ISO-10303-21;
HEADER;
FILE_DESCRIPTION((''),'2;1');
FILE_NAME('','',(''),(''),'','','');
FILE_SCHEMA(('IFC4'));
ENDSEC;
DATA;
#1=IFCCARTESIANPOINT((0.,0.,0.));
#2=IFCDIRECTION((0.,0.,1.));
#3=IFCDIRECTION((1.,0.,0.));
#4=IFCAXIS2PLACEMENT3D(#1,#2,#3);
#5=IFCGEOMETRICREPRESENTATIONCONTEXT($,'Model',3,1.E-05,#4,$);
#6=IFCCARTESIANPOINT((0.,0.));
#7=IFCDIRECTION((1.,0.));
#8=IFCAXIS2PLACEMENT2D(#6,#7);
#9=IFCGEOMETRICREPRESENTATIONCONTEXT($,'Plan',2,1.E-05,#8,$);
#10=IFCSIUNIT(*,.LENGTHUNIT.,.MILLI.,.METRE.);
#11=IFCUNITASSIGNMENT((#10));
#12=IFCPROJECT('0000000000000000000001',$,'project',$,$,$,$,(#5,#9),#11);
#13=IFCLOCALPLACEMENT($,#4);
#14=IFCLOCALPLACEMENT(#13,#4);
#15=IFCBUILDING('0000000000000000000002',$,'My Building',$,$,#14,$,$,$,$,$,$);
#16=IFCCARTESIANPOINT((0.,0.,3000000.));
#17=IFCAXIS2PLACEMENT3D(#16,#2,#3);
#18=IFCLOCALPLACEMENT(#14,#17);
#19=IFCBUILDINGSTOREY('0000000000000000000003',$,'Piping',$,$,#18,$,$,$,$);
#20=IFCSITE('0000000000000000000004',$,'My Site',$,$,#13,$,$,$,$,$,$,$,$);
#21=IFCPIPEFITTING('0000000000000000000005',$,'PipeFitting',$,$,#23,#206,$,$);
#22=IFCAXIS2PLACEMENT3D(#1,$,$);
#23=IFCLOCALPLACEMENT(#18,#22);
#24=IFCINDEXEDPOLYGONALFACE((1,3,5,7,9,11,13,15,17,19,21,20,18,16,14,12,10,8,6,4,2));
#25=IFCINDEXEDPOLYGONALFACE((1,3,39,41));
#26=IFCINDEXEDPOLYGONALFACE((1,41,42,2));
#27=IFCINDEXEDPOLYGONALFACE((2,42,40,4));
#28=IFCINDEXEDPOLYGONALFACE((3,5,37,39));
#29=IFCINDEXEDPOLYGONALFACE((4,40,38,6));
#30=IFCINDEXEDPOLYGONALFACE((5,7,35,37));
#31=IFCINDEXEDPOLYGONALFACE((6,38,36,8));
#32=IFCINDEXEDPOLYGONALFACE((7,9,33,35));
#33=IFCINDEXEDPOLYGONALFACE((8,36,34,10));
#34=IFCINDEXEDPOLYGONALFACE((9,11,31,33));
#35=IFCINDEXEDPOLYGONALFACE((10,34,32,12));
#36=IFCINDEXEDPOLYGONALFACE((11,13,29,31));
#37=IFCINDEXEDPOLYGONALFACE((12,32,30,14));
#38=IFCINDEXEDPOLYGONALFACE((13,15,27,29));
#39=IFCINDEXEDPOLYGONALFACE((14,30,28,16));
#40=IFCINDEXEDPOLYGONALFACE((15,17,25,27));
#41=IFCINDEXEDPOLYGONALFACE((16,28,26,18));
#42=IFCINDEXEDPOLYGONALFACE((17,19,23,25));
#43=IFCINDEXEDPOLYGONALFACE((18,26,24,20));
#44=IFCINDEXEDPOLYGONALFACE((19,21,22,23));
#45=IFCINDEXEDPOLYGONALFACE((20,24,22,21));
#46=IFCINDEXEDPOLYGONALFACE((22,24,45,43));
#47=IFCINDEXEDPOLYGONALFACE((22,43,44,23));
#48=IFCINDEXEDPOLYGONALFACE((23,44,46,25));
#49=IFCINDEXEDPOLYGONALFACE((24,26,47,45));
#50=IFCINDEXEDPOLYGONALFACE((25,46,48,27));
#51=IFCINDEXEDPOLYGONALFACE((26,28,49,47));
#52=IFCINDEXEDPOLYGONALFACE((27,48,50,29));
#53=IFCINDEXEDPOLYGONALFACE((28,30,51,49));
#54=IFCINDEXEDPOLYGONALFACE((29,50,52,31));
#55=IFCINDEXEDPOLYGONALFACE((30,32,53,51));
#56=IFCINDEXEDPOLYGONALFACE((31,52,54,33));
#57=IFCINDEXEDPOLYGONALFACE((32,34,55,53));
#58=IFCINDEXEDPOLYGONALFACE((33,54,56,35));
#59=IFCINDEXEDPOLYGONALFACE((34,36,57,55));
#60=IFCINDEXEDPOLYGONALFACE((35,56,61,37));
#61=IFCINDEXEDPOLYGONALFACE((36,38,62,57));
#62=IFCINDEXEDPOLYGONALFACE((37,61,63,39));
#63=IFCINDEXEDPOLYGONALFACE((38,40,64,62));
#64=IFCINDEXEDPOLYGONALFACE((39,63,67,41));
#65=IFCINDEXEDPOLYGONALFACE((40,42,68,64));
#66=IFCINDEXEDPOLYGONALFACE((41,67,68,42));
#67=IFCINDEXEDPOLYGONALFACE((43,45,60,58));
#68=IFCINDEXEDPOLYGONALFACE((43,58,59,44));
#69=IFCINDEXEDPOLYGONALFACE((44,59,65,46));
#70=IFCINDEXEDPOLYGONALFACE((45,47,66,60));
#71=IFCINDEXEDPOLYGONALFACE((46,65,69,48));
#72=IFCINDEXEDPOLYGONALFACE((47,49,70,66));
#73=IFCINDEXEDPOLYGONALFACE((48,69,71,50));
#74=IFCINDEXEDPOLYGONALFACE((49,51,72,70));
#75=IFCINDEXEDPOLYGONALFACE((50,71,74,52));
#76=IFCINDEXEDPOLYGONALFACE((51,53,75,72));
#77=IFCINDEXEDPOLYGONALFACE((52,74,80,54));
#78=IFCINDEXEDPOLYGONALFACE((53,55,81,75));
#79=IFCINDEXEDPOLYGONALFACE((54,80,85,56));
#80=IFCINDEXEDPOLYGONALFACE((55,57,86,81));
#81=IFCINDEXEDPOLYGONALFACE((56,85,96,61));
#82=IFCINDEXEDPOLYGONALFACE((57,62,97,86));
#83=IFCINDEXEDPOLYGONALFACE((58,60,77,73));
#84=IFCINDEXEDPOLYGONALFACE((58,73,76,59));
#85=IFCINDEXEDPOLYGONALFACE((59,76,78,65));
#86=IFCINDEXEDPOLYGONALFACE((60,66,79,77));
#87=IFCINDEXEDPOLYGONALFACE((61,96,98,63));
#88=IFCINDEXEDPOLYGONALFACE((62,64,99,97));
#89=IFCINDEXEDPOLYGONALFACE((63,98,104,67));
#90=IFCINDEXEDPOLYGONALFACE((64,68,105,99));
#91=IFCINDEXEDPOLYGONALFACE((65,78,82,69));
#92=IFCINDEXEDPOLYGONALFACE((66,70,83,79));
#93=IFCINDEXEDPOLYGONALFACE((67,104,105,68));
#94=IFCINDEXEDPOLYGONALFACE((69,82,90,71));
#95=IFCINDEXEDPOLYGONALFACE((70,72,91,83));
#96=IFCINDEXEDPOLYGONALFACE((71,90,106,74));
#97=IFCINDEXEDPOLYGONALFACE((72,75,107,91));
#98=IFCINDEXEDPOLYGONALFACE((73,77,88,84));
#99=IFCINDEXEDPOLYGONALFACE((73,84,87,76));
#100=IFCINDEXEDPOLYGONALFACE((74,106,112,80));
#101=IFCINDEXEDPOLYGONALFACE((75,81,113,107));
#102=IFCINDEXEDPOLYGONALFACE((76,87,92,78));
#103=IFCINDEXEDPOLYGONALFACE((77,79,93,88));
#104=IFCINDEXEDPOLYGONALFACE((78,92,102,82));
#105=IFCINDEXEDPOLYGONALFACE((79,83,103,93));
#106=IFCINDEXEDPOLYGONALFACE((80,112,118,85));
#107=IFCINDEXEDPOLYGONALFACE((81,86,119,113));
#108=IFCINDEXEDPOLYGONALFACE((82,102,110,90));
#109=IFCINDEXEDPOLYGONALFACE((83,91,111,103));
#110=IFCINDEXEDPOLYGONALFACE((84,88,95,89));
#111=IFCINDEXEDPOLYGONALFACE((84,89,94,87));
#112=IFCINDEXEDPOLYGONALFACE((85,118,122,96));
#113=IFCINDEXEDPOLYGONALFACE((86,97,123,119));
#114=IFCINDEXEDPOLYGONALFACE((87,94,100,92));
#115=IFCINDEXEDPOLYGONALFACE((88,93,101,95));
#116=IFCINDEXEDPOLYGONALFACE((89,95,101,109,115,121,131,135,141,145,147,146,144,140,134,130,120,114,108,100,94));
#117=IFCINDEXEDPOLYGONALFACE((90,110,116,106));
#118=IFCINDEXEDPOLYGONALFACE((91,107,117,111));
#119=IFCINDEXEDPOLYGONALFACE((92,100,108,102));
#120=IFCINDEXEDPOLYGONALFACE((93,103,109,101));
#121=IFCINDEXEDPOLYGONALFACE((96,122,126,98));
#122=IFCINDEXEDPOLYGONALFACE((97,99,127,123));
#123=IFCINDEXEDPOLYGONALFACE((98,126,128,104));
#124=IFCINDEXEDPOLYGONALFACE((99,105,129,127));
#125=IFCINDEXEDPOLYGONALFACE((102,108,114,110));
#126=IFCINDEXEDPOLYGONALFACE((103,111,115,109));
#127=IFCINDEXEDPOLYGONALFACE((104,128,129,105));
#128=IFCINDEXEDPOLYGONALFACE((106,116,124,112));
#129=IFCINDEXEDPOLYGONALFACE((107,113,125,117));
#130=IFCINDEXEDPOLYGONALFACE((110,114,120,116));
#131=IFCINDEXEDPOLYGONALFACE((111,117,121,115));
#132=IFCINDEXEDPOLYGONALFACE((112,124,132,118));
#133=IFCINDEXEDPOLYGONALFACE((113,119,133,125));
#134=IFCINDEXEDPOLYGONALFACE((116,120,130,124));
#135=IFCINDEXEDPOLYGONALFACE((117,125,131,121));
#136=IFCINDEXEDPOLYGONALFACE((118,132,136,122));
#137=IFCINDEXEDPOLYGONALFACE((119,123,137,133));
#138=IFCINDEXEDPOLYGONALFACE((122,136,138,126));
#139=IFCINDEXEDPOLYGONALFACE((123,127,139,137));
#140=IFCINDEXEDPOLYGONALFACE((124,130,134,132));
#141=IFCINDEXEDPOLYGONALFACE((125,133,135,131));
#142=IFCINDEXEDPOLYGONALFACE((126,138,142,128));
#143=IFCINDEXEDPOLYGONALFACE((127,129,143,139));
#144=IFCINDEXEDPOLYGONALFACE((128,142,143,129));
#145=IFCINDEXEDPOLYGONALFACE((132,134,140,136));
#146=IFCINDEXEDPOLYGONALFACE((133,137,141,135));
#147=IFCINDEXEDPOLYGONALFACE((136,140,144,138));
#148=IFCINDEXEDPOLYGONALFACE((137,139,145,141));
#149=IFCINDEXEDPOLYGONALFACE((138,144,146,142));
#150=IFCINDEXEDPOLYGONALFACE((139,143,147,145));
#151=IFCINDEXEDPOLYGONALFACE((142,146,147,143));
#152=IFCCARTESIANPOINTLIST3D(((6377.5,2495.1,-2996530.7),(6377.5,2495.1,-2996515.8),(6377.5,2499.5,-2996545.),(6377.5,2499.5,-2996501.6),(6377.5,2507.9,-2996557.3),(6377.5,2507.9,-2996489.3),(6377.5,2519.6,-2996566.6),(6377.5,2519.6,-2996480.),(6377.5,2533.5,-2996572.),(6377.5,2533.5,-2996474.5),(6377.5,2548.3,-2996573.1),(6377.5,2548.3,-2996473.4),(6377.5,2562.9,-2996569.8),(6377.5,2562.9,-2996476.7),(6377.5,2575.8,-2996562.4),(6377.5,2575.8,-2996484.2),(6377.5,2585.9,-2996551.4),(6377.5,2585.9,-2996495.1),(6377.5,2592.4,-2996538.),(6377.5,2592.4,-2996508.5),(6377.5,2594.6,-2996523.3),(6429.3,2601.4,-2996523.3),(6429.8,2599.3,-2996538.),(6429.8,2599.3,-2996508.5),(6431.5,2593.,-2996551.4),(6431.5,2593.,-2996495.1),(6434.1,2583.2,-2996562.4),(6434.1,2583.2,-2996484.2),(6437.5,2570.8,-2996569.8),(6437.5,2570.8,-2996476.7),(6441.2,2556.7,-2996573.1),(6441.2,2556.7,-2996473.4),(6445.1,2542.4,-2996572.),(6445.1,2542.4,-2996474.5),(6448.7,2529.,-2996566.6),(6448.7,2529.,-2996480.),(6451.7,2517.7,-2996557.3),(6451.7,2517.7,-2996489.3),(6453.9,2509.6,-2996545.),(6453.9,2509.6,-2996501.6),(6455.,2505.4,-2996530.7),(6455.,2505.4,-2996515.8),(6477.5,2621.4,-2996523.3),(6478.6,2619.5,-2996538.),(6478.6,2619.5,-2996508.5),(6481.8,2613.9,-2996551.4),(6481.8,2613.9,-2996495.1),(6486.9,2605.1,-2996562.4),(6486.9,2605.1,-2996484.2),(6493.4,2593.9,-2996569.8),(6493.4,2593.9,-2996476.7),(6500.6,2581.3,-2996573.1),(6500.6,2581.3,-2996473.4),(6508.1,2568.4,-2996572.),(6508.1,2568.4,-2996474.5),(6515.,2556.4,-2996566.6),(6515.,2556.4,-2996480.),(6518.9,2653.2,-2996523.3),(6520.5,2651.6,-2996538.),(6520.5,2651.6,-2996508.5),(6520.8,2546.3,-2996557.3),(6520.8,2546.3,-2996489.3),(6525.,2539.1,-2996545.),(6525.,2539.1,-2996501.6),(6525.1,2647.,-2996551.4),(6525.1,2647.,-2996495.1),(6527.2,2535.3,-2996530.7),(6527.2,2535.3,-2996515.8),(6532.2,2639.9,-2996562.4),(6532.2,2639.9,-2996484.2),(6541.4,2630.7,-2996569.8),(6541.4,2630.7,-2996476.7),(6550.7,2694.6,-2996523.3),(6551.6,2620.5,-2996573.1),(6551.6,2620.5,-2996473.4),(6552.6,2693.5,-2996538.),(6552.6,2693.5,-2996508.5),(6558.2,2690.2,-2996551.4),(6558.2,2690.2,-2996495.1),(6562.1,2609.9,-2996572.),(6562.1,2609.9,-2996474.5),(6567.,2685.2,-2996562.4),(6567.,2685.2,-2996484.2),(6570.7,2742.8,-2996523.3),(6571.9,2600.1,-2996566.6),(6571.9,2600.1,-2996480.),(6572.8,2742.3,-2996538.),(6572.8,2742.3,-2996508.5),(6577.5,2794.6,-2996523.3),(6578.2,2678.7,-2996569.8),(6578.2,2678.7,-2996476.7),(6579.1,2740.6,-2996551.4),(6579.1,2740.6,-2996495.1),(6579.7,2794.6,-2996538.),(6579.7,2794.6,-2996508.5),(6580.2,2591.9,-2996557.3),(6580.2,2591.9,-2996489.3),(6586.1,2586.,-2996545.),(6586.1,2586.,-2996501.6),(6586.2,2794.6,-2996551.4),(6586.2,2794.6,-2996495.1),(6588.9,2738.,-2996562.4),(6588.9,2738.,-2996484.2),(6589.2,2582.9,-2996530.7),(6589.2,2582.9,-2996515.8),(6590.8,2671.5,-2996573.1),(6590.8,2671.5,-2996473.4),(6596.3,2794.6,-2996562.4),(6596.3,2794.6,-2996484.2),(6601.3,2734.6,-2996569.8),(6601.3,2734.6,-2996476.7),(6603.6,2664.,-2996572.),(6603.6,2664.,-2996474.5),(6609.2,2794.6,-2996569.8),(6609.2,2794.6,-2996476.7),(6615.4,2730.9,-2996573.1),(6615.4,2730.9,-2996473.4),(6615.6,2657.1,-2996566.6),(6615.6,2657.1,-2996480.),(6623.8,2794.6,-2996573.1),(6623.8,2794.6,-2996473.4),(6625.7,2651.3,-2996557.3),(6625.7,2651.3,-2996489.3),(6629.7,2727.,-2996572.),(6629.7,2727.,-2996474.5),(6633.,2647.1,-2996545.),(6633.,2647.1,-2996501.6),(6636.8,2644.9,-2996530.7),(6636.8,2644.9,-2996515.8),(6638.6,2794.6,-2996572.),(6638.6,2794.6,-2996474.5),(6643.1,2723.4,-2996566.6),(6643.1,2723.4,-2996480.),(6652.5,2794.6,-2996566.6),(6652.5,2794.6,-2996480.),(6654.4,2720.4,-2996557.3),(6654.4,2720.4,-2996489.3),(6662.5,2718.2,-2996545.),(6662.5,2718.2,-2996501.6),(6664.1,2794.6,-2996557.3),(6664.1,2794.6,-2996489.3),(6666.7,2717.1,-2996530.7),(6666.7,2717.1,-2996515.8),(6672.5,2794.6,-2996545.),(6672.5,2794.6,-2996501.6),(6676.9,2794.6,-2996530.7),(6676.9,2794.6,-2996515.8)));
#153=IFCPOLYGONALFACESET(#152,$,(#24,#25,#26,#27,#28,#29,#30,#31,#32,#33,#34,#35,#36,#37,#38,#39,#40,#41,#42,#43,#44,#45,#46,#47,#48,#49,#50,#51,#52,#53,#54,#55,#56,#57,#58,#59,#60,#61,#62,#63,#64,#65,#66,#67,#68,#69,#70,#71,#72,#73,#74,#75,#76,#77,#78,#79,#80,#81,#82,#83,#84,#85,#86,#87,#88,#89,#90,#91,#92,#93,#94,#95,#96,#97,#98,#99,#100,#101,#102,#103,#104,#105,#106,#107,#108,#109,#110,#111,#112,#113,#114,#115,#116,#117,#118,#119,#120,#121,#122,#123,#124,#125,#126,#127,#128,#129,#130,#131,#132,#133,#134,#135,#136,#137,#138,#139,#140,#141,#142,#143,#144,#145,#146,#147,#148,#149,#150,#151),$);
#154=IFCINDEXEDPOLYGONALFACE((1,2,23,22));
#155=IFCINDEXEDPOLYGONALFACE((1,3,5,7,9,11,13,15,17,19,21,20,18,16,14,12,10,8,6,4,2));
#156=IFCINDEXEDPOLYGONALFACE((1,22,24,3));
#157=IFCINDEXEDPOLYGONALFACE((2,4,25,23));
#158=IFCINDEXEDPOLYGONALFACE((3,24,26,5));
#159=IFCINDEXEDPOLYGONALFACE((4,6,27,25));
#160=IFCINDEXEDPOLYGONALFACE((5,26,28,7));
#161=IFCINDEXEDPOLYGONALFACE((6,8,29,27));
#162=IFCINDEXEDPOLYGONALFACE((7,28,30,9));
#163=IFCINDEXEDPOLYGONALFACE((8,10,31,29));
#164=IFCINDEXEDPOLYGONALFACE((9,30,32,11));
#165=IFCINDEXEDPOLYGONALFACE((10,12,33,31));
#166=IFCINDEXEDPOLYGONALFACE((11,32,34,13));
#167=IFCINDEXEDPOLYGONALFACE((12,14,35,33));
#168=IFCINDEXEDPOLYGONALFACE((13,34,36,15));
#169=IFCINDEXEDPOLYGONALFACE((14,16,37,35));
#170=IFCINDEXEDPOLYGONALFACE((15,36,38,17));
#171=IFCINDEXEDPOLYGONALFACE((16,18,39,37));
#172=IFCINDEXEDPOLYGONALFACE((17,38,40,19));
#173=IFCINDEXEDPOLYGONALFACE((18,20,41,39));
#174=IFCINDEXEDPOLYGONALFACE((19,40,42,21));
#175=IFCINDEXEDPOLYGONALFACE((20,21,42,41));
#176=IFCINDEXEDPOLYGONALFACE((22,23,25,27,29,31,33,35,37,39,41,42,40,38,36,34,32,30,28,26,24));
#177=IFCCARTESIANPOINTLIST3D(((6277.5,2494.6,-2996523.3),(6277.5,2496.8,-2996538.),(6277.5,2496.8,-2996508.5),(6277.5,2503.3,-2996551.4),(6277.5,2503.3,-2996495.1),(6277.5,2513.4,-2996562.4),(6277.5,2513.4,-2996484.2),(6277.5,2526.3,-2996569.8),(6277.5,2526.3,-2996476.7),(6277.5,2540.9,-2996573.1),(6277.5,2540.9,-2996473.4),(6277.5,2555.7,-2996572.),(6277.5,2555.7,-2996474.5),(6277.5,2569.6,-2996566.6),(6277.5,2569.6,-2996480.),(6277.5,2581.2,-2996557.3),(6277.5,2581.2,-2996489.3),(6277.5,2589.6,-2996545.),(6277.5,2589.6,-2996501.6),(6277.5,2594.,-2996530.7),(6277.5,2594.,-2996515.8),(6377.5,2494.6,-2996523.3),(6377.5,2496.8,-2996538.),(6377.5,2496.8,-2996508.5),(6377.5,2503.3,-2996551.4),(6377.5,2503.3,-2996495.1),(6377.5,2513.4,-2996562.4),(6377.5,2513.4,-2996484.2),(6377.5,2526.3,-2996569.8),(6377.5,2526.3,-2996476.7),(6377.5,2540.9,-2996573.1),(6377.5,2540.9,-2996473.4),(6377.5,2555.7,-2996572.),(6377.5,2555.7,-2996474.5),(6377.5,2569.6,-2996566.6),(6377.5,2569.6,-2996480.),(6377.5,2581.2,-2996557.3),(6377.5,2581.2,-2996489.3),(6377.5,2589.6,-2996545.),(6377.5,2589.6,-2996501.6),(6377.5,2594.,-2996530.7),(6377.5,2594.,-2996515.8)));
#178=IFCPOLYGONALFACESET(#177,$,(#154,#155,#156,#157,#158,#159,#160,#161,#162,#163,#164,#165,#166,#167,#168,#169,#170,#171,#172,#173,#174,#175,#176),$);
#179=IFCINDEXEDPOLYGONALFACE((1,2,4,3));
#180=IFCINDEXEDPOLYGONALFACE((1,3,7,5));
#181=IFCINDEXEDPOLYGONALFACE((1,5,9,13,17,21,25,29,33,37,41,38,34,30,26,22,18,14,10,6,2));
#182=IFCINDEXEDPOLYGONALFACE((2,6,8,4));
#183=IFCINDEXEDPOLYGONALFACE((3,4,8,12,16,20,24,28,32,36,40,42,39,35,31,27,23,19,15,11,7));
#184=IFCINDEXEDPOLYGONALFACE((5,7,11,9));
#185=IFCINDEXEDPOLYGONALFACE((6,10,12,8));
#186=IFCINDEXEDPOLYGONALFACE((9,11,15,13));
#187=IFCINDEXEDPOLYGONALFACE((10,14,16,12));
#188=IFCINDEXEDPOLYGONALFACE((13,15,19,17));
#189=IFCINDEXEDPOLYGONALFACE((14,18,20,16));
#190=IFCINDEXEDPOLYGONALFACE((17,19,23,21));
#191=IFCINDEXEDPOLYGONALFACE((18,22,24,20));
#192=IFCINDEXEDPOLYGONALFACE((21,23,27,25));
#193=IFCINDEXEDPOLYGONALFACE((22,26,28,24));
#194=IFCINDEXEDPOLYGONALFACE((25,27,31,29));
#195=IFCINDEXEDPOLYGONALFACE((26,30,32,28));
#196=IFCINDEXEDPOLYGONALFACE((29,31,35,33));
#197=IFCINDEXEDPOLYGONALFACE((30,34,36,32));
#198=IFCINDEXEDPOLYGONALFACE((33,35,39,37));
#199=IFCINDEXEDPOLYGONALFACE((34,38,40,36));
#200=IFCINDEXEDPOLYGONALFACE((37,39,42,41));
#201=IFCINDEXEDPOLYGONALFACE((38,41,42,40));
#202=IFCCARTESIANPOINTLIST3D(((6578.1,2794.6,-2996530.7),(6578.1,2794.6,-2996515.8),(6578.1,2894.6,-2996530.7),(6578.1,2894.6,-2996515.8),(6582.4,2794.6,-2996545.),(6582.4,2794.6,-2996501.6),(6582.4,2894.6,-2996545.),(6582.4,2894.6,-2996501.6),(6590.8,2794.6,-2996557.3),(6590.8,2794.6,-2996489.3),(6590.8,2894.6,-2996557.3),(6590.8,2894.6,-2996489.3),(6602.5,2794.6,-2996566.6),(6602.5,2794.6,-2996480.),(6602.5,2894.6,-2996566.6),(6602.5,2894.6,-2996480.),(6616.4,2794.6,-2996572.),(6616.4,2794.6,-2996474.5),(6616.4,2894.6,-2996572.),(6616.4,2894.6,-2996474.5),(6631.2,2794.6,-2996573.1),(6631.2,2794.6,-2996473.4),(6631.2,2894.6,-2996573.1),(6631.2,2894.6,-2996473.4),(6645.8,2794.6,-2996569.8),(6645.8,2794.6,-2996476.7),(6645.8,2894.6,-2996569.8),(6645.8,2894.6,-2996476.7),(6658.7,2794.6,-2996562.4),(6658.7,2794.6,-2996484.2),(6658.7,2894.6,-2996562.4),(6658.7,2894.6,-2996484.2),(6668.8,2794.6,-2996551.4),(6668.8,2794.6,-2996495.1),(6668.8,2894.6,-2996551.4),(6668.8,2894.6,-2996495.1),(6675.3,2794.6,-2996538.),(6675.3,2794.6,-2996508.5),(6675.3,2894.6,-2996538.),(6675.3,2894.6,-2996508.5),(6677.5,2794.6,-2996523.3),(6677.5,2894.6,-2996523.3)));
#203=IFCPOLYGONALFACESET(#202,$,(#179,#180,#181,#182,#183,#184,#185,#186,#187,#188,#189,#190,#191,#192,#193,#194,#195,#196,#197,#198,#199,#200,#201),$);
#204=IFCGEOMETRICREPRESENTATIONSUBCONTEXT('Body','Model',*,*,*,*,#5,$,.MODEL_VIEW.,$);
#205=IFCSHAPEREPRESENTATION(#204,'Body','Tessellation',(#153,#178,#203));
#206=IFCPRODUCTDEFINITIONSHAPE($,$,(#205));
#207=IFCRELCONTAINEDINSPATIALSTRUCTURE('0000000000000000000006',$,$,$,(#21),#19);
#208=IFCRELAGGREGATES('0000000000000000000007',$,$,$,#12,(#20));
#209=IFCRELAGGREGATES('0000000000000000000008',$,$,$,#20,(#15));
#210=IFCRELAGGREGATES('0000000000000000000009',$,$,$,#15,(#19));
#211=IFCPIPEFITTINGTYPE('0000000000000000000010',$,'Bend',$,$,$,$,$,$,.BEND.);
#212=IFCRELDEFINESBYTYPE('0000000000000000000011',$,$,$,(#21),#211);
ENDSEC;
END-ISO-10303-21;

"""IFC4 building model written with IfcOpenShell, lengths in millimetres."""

from ifc_helpers import new_model, entity, si_unit, frame, origin_with_axes, origin_2d_with_axis, place, context, subcontext, project, spatial, line, indexed_curve, circle, outline, extrude, source, transform, mapped, type_object, type_shapes, element, save


model = new_model("IFC4")

# Units and contexts
model_context = context("Model", 3, precision=1e-05, world=origin_with_axes())
plan_context = context("Plan", 2, precision=1e-05, world=origin_2d_with_axis())
body_context = subcontext(model_context, "Body", "Model", "MODEL_VIEW")
ifc_project = project(units=[si_unit("LENGTHUNIT", "METRE", prefix="MILLI")], contexts=[model_context, plan_context])

# Site, building, storey
site_placement = place(None, origin_with_axes())
site = spatial("IfcSite", under=ifc_project, at=site_placement, Name="My Site")
building_placement = place(site_placement, origin_with_axes())
building = spatial("IfcBuilding", under=site, at=building_placement, Name="My Building")
storey_placement = place(building_placement, frame((0.0, 0.0, 3000000.0), z_axis=(0.0, 0.0, 1.0), x_axis=(1.0, 0.0, 0.0)))
storey = spatial("IfcBuildingStorey", under=building, at=storey_placement, Name="Piping")

# Pipe fitting, opening
pipe_fitting_type_1 = type_object("IfcPipeFittingType", Name="Bend", PredefinedType="BEND")
shared_shape_1 = source(origin_with_axes(), body_context, "Body", "SolidModel", [
    entity("IfcSweptDiskSolid", entity("IfcIndexedPolyCurve", entity("IfcCartesianPointList3D", [[0.0, 0.0, -100.0], [-73.2, 0.0, -276.8], [-250.0, 0.0, -350.0]]), [entity("IfcArcIndex", [1, 2, 3])]), 50.0),
    extrude(circle(Radius=50.0), origin_with_axes(), (0.0, 0.0, -1.0), 100.0),
    extrude(circle(Radius=50.0), frame((-250.0, 0.0, -350.0), z_axis=(-1.0, 0.0, 0.0), x_axis=(0.0, 0.0, -1.0)), (0.0, 0.0, 1.0), 100.0),
])
type_shapes(pipe_fitting_type_1, [shared_shape_1])
pipe_fitting_1_placement = place(storey_placement, frame((6277.5, 2544.6, -2996523.3), z_axis=(-1.0, 0.0, 0.0), x_axis=(0.0, -1.0, 0.0)))
pipe_fitting_1 = element("IfcPipeFitting", 1, at=pipe_fitting_1_placement, inside=storey, type_object=pipe_fitting_type_1, Name="PipeFitting", context=body_context, shape_type="MappedRepresentation", body=[
    mapped(shared_shape_1, transform((0.0, 0.0, 0.0), x_axis=(1.0, 0.0, 0.0), y_axis=(0.0, 1.0, 0.0), z_axis=(0.0, 0.0, 1.0), scale=1.0)),
])
opening_placement = place(pipe_fitting_1_placement, frame((2544.6, -3476.7, 6277.5), z_axis=(0.0, 1.0, 0.0), x_axis=(0.0, 0.0, -1.0)))
element("IfcOpeningElement", 2, at=opening_placement, cuts=pipe_fitting_1, PredefinedType="OPENING", context=body_context, shape_type="SweptSolid", body=[
    extrude(outline(indexed_curve([(0.0, 0.0), (500.0, 0.0), (500.0, 500.0), (0.0, 500.0)], segments=[line(1, 2, 3, 4, 1)])), origin_with_axes(), (0.0, 0.0, 1.0), 500.0),
])

save(model, "model.ifc")
